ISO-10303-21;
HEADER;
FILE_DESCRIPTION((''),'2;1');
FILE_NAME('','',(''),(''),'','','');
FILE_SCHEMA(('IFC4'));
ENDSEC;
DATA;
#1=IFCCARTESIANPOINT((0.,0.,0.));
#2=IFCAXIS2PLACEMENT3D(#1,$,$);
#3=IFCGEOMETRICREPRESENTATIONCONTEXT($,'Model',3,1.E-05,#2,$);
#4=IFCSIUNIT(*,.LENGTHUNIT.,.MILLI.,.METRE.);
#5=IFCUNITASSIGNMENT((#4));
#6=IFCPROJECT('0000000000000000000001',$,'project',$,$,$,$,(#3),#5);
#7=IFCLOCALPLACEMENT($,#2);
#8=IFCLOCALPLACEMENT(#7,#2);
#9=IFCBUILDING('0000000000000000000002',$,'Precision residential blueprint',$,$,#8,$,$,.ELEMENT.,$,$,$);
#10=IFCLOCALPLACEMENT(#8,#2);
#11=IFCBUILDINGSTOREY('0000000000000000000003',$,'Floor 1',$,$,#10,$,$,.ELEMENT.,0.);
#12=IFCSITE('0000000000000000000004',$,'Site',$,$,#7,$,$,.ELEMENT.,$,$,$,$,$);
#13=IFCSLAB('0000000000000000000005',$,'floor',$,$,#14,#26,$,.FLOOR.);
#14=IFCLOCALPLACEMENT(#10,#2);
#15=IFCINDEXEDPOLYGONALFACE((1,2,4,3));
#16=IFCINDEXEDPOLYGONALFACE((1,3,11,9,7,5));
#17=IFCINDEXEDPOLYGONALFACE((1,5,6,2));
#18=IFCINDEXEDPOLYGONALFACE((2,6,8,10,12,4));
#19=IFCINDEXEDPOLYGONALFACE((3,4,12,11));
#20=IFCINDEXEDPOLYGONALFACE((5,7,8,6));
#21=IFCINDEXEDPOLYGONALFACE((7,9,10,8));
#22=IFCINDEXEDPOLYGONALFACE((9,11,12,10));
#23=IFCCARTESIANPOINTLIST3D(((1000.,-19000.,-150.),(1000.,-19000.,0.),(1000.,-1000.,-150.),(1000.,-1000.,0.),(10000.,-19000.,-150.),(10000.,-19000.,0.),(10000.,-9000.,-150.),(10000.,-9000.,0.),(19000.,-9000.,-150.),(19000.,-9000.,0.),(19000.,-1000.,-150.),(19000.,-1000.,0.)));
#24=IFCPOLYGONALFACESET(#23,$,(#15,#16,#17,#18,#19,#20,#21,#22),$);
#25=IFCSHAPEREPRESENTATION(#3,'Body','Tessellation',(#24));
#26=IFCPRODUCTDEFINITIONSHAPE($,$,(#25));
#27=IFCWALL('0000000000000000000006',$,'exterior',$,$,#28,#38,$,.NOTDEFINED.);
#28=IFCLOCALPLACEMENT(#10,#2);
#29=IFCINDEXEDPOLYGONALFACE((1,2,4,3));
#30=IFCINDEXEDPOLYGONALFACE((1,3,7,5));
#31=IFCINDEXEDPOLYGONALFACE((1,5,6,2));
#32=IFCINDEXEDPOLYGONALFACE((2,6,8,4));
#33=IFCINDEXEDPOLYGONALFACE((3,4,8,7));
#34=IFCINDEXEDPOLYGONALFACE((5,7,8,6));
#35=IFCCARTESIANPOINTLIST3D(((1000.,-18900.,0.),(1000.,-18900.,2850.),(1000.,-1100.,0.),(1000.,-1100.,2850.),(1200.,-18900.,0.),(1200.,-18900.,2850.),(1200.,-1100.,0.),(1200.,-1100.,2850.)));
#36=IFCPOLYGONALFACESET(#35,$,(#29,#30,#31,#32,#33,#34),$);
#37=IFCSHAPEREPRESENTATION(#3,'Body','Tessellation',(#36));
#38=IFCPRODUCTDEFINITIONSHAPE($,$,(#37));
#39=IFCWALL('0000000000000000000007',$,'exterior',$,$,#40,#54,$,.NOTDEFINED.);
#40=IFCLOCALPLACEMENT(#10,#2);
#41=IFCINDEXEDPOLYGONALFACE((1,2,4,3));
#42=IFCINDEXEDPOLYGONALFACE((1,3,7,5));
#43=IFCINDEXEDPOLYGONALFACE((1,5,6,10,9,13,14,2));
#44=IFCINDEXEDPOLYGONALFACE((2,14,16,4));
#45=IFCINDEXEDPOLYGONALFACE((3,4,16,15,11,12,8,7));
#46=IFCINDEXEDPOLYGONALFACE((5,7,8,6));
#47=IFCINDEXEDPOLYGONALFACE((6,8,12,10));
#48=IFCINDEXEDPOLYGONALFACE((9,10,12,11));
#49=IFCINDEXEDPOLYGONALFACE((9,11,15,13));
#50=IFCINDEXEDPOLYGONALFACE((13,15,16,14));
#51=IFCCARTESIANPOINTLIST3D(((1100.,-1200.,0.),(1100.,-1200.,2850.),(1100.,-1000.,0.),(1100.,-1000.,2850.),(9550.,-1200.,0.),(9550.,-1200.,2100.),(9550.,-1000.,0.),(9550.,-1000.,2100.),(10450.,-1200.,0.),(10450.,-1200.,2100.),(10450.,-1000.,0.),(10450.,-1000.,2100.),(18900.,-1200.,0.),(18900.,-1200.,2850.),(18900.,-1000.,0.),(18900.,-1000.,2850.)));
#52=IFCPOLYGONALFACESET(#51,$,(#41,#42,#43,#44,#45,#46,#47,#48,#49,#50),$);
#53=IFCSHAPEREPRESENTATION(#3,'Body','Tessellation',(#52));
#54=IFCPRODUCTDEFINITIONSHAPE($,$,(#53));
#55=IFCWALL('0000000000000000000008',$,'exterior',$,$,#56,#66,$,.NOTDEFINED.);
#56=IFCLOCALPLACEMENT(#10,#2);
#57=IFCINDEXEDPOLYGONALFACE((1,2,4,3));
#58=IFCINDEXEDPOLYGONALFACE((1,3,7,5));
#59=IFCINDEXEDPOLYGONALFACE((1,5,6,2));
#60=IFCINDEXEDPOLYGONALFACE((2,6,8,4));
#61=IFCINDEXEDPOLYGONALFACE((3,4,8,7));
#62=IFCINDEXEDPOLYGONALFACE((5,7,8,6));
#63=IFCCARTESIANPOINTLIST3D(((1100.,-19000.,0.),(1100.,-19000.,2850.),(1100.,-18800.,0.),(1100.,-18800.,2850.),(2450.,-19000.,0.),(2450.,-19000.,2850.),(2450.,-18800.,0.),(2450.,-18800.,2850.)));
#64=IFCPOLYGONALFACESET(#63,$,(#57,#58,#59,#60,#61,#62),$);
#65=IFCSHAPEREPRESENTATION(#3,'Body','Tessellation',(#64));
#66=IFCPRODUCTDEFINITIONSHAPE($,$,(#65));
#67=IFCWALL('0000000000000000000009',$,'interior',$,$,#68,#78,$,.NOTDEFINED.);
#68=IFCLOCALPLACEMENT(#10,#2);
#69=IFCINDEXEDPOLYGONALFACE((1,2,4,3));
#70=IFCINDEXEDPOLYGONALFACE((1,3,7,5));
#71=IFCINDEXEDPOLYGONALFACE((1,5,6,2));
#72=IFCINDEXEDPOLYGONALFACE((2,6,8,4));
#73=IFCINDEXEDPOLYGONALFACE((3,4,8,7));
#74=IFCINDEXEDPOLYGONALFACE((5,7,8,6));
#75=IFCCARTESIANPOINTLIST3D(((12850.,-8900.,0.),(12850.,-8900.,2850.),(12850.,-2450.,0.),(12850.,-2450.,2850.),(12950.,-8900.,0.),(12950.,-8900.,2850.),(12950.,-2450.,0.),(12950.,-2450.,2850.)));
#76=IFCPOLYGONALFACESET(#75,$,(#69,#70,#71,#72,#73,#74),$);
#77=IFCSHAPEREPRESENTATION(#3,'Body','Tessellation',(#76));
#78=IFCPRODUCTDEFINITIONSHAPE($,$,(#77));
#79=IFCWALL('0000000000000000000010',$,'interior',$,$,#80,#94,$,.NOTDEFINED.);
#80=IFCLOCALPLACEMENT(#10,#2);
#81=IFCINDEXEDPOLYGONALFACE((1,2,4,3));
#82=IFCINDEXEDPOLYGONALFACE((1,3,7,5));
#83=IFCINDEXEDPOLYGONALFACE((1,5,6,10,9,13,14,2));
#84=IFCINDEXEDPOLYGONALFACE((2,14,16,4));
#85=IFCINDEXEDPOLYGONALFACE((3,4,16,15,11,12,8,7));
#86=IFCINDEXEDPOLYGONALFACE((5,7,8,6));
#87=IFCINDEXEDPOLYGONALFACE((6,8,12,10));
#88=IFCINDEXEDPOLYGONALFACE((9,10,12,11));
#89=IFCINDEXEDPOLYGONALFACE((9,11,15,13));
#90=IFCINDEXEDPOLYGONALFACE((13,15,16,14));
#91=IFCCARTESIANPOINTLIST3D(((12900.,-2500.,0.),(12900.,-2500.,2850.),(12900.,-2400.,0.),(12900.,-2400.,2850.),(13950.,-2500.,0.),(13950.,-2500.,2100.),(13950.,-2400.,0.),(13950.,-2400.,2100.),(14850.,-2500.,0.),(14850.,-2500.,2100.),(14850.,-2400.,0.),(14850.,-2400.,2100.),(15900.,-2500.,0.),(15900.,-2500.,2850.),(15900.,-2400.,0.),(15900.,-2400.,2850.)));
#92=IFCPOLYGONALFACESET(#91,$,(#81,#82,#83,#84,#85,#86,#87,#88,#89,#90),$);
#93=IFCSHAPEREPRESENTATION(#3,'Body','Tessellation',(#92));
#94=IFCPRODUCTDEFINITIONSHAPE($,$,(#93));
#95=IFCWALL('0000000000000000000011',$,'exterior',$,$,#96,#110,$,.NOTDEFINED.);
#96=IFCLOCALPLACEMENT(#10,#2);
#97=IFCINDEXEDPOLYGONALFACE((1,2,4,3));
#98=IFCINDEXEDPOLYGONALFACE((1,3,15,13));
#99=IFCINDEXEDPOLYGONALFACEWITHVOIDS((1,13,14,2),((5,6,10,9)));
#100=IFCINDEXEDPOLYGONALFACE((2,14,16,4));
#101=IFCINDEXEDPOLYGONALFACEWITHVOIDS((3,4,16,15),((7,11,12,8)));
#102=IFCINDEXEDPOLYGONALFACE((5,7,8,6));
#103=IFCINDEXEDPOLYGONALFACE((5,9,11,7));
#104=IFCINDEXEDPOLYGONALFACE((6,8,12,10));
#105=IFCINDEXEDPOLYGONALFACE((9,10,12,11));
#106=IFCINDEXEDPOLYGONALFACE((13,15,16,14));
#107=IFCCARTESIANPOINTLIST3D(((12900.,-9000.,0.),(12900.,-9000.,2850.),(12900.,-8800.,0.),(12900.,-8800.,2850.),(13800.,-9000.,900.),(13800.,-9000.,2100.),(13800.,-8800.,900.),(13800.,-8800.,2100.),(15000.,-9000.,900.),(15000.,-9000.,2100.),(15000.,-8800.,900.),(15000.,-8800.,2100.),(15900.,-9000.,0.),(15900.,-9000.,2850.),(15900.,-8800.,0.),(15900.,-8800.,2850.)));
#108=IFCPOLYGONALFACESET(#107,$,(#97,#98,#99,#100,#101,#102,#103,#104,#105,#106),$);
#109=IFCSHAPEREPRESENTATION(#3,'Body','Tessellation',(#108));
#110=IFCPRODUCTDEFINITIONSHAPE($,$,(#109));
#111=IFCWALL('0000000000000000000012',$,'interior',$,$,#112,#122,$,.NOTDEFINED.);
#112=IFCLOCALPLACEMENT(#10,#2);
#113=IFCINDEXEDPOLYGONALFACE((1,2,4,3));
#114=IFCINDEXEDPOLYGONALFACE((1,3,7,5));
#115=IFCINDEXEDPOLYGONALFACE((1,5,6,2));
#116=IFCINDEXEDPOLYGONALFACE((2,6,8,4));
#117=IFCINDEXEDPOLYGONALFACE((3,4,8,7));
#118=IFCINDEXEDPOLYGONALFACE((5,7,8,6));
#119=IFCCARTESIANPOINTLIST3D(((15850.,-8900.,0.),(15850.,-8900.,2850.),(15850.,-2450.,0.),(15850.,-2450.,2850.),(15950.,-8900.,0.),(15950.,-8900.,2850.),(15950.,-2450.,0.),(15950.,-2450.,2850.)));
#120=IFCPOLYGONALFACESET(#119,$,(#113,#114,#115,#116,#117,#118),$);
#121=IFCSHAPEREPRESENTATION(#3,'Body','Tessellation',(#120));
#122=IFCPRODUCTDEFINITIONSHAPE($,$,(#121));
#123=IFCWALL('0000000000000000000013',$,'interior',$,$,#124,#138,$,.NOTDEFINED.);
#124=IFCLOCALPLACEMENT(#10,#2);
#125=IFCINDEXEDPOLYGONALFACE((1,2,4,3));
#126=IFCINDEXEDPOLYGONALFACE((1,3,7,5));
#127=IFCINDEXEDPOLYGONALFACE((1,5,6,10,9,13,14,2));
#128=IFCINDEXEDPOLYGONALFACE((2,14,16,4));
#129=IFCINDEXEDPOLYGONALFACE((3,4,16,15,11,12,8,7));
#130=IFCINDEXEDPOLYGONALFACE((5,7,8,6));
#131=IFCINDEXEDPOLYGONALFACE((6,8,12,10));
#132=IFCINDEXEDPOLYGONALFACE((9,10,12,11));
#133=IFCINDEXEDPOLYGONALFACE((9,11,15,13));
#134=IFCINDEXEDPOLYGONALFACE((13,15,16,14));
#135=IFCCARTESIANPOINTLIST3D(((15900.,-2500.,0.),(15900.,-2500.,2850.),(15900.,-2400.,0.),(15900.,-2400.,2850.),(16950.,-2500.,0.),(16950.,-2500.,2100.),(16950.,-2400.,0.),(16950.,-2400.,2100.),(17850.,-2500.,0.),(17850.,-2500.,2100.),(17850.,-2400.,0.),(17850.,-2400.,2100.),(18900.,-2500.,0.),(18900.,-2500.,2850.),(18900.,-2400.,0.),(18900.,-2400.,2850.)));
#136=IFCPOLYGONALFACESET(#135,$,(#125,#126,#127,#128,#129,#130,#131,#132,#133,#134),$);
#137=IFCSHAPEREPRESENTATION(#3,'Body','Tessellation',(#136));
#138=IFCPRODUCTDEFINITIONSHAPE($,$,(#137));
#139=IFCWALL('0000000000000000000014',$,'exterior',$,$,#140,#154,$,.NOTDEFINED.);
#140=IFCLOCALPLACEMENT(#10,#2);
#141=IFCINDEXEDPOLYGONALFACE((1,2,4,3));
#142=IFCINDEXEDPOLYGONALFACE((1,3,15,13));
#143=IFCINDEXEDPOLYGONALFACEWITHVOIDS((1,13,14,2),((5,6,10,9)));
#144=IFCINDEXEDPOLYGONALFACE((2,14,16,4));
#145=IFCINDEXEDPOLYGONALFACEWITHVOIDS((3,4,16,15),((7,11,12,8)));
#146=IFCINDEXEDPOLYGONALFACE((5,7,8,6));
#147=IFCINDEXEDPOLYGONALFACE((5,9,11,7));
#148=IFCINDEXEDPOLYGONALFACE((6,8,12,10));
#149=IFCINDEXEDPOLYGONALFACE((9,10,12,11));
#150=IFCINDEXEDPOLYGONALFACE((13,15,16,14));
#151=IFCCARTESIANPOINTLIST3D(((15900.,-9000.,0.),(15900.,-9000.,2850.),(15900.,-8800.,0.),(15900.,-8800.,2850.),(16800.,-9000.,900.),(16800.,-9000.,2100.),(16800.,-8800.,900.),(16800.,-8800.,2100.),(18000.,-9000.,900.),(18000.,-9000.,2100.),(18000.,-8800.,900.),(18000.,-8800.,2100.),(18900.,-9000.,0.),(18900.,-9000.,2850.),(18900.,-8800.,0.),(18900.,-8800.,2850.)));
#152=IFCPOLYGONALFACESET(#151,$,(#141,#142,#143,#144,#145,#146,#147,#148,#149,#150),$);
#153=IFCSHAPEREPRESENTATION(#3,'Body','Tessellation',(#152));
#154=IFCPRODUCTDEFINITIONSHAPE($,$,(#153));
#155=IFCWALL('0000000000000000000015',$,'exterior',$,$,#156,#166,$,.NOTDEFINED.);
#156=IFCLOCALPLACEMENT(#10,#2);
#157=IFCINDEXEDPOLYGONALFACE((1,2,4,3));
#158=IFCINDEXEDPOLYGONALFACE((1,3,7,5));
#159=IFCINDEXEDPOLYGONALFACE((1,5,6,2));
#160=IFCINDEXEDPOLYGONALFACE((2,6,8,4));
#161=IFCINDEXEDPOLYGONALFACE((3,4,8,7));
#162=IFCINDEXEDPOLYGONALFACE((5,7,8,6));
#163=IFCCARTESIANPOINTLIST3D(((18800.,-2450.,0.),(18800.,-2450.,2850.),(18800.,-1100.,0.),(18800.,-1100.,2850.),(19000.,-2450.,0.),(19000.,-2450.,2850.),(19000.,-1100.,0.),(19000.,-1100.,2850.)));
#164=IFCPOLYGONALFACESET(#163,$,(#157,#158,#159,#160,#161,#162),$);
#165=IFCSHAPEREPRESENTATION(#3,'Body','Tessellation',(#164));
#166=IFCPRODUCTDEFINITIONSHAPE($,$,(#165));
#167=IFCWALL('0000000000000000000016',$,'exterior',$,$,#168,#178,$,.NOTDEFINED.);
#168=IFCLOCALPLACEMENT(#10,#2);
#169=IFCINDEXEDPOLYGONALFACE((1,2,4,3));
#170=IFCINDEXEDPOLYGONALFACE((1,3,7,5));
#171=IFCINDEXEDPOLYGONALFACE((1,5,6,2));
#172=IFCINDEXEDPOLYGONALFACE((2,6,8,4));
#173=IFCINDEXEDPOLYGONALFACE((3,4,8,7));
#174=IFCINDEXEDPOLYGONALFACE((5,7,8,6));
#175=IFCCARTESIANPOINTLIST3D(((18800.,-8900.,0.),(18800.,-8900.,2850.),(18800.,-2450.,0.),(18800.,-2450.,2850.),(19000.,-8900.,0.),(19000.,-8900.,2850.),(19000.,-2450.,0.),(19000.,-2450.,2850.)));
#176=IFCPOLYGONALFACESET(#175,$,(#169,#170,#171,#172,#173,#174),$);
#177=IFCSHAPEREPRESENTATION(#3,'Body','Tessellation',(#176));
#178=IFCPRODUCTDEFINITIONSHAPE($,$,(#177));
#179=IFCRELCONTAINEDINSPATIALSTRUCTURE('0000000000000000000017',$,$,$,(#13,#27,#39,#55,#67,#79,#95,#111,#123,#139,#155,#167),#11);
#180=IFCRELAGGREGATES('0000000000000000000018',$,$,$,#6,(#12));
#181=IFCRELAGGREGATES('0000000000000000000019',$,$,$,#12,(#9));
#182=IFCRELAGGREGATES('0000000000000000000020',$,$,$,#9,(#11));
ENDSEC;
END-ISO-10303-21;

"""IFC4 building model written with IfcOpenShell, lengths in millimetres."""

from ifc_helpers import new_model, si_unit, frame, origin, place, context, project, spatial, polyline, outline, extrude, element, save


model = new_model("IFC4")

# Units and contexts
model_context = context("Model", 3, precision=1e-05, world=origin())
ifc_project = project(units=[si_unit("LENGTHUNIT", "METRE", prefix="MILLI")], contexts=[model_context])

# Site, building, storey
site_placement = place(None, origin())
site = spatial("IfcSite", under=ifc_project, at=site_placement, Name="Site", CompositionType="ELEMENT")
building_placement = place(site_placement, origin())
building = spatial("IfcBuilding", under=site, at=building_placement, Name="Precision residential blueprint", CompositionType="ELEMENT")
storey_placement = place(building_placement, origin())
storey = spatial("IfcBuildingStorey", under=building, at=storey_placement, Name="Floor 1", CompositionType="ELEMENT", Elevation=0.0)

# Slab
slab_placement = place(storey_placement, origin())
element("IfcSlab", 1, at=slab_placement, inside=storey, Name="floor", PredefinedType="FLOOR", context=model_context, shape_type="SweptSolid", body=[
    extrude(outline(polyline([(1000.0, -19000.0), (10000.0, -19000.0), (10000.0, -9000.0), (19000.0, -9000.0), (19000.0, -1000.0), (1000.0, -1000.0), (1000.0, -19000.0)])), frame((0.0, 0.0, -150.0)), (0.0, 0.0, 1.0), 150.0),
])

# Wall
wall_1_placement = place(storey_placement, origin())
element("IfcWall", 2, at=wall_1_placement, inside=storey, Name="exterior", PredefinedType="NOTDEFINED", context=model_context, shape_type="SweptSolid", body=[
    extrude(outline(polyline([(1200.0, -1100.0), (1200.0, -18900.0), (1000.0, -18900.0), (1000.0, -1100.0), (1200.0, -1100.0)])), origin(), (0.0, 0.0, 1.0), 2850.0),
])

# Wall, opening
wall_2_placement = place(storey_placement, origin())
wall_2 = element("IfcWall", 3, at=wall_2_placement, inside=storey, Name="exterior", PredefinedType="NOTDEFINED", context=model_context, shape_type="SweptSolid", body=[
    extrude(outline(polyline([(1100.0, -1000.0), (18900.0, -1000.0), (18900.0, -1200.0), (1100.0, -1200.0), (1100.0, -1000.0)])), origin(), (0.0, 0.0, 1.0), 2850.0),
])
opening_1_placement = place(storey_placement, origin())
element("IfcOpeningElement", 4, at=opening_1_placement, cuts=wall_2, PredefinedType="OPENING", context=model_context, shape_type="SweptSolid", body=[
    extrude(outline(polyline([(9550.0, -1000.0), (10450.0, -1000.0), (10450.0, -1200.0), (9550.0, -1200.0), (9550.0, -1000.0)])), origin(), (0.0, 0.0, 1.0), 2100.0),
])

# Walls
wall_3_placement = place(storey_placement, origin())
element("IfcWall", 5, at=wall_3_placement, inside=storey, Name="exterior", PredefinedType="NOTDEFINED", context=model_context, shape_type="SweptSolid", body=[
    extrude(outline(polyline([(1100.0, -18800.0), (2450.0, -18800.0), (2450.0, -19000.0), (1100.0, -19000.0), (1100.0, -18800.0)])), origin(), (0.0, 0.0, 1.0), 2850.0),
])
wall_4_placement = place(storey_placement, origin())
element("IfcWall", 6, at=wall_4_placement, inside=storey, Name="interior", PredefinedType="NOTDEFINED", context=model_context, shape_type="SweptSolid", body=[
    extrude(outline(polyline([(12950.0, -2450.0), (12950.0, -8900.0), (12850.0, -8900.0), (12850.0, -2450.0), (12950.0, -2450.0)])), origin(), (0.0, 0.0, 1.0), 2850.0),
])

# Walls, openings
wall_5_placement = place(storey_placement, origin())
wall_5 = element("IfcWall", 7, at=wall_5_placement, inside=storey, Name="interior", PredefinedType="NOTDEFINED", context=model_context, shape_type="SweptSolid", body=[
    extrude(outline(polyline([(12900.0, -2400.0), (15900.0, -2400.0), (15900.0, -2500.0), (12900.0, -2500.0), (12900.0, -2400.0)])), origin(), (0.0, 0.0, 1.0), 2850.0),
])
opening_2_placement = place(storey_placement, origin())
element("IfcOpeningElement", 8, at=opening_2_placement, cuts=wall_5, PredefinedType="OPENING", context=model_context, shape_type="SweptSolid", body=[
    extrude(outline(polyline([(13950.0, -2400.0), (14850.0, -2400.0), (14850.0, -2500.0), (13950.0, -2500.0), (13950.0, -2400.0)])), origin(), (0.0, 0.0, 1.0), 2100.0),
])
wall_6_placement = place(storey_placement, origin())
wall_6 = element("IfcWall", 9, at=wall_6_placement, inside=storey, Name="exterior", PredefinedType="NOTDEFINED", context=model_context, shape_type="SweptSolid", body=[
    extrude(outline(polyline([(12900.0, -8800.0), (15900.0, -8800.0), (15900.0, -9000.0), (12900.0, -9000.0), (12900.0, -8800.0)])), origin(), (0.0, 0.0, 1.0), 2850.0),
])
opening_3_placement = place(storey_placement, origin())
element("IfcOpeningElement", 10, at=opening_3_placement, cuts=wall_6, PredefinedType="OPENING", context=model_context, shape_type="SweptSolid", body=[
    extrude(outline(polyline([(13800.0, -8800.0), (15000.0, -8800.0), (15000.0, -9000.0), (13800.0, -9000.0), (13800.0, -8800.0)])), frame((0.0, 0.0, 900.0)), (0.0, 0.0, 1.0), 1200.0),
])

# Wall
wall_7_placement = place(storey_placement, origin())
element("IfcWall", 11, at=wall_7_placement, inside=storey, Name="interior", PredefinedType="NOTDEFINED", context=model_context, shape_type="SweptSolid", body=[
    extrude(outline(polyline([(15950.0, -2450.0), (15950.0, -8900.0), (15850.0, -8900.0), (15850.0, -2450.0), (15950.0, -2450.0)])), origin(), (0.0, 0.0, 1.0), 2850.0),
])

# Walls, openings
wall_8_placement = place(storey_placement, origin())
wall_8 = element("IfcWall", 12, at=wall_8_placement, inside=storey, Name="interior", PredefinedType="NOTDEFINED", context=model_context, shape_type="SweptSolid", body=[
    extrude(outline(polyline([(15900.0, -2400.0), (18900.0, -2400.0), (18900.0, -2500.0), (15900.0, -2500.0), (15900.0, -2400.0)])), origin(), (0.0, 0.0, 1.0), 2850.0),
])
opening_4_placement = place(storey_placement, origin())
element("IfcOpeningElement", 13, at=opening_4_placement, cuts=wall_8, PredefinedType="OPENING", context=model_context, shape_type="SweptSolid", body=[
    extrude(outline(polyline([(16950.0, -2400.0), (17850.0, -2400.0), (17850.0, -2500.0), (16950.0, -2500.0), (16950.0, -2400.0)])), origin(), (0.0, 0.0, 1.0), 2100.0),
])
wall_9_placement = place(storey_placement, origin())
wall_9 = element("IfcWall", 14, at=wall_9_placement, inside=storey, Name="exterior", PredefinedType="NOTDEFINED", context=model_context, shape_type="SweptSolid", body=[
    extrude(outline(polyline([(15900.0, -8800.0), (18900.0, -8800.0), (18900.0, -9000.0), (15900.0, -9000.0), (15900.0, -8800.0)])), origin(), (0.0, 0.0, 1.0), 2850.0),
])
opening_5_placement = place(storey_placement, origin())
element("IfcOpeningElement", 15, at=opening_5_placement, cuts=wall_9, PredefinedType="OPENING", context=model_context, shape_type="SweptSolid", body=[
    extrude(outline(polyline([(16800.0, -8800.0), (18000.0, -8800.0), (18000.0, -9000.0), (16800.0, -9000.0), (16800.0, -8800.0)])), frame((0.0, 0.0, 900.0)), (0.0, 0.0, 1.0), 1200.0),
])

# Walls
wall_10_placement = place(storey_placement, origin())
element("IfcWall", 16, at=wall_10_placement, inside=storey, Name="exterior", PredefinedType="NOTDEFINED", context=model_context, shape_type="SweptSolid", body=[
    extrude(outline(polyline([(19000.0, -1100.0), (19000.0, -2450.0), (18800.0, -2450.0), (18800.0, -1100.0), (19000.0, -1100.0)])), origin(), (0.0, 0.0, 1.0), 2850.0),
])
wall_11_placement = place(storey_placement, origin())
element("IfcWall", 17, at=wall_11_placement, inside=storey, Name="exterior", PredefinedType="NOTDEFINED", context=model_context, shape_type="SweptSolid", body=[
    extrude(outline(polyline([(19000.0, -2450.0), (19000.0, -8900.0), (18800.0, -8900.0), (18800.0, -2450.0), (19000.0, -2450.0)])), origin(), (0.0, 0.0, 1.0), 2850.0),
])

save(model, "model.ifc")
